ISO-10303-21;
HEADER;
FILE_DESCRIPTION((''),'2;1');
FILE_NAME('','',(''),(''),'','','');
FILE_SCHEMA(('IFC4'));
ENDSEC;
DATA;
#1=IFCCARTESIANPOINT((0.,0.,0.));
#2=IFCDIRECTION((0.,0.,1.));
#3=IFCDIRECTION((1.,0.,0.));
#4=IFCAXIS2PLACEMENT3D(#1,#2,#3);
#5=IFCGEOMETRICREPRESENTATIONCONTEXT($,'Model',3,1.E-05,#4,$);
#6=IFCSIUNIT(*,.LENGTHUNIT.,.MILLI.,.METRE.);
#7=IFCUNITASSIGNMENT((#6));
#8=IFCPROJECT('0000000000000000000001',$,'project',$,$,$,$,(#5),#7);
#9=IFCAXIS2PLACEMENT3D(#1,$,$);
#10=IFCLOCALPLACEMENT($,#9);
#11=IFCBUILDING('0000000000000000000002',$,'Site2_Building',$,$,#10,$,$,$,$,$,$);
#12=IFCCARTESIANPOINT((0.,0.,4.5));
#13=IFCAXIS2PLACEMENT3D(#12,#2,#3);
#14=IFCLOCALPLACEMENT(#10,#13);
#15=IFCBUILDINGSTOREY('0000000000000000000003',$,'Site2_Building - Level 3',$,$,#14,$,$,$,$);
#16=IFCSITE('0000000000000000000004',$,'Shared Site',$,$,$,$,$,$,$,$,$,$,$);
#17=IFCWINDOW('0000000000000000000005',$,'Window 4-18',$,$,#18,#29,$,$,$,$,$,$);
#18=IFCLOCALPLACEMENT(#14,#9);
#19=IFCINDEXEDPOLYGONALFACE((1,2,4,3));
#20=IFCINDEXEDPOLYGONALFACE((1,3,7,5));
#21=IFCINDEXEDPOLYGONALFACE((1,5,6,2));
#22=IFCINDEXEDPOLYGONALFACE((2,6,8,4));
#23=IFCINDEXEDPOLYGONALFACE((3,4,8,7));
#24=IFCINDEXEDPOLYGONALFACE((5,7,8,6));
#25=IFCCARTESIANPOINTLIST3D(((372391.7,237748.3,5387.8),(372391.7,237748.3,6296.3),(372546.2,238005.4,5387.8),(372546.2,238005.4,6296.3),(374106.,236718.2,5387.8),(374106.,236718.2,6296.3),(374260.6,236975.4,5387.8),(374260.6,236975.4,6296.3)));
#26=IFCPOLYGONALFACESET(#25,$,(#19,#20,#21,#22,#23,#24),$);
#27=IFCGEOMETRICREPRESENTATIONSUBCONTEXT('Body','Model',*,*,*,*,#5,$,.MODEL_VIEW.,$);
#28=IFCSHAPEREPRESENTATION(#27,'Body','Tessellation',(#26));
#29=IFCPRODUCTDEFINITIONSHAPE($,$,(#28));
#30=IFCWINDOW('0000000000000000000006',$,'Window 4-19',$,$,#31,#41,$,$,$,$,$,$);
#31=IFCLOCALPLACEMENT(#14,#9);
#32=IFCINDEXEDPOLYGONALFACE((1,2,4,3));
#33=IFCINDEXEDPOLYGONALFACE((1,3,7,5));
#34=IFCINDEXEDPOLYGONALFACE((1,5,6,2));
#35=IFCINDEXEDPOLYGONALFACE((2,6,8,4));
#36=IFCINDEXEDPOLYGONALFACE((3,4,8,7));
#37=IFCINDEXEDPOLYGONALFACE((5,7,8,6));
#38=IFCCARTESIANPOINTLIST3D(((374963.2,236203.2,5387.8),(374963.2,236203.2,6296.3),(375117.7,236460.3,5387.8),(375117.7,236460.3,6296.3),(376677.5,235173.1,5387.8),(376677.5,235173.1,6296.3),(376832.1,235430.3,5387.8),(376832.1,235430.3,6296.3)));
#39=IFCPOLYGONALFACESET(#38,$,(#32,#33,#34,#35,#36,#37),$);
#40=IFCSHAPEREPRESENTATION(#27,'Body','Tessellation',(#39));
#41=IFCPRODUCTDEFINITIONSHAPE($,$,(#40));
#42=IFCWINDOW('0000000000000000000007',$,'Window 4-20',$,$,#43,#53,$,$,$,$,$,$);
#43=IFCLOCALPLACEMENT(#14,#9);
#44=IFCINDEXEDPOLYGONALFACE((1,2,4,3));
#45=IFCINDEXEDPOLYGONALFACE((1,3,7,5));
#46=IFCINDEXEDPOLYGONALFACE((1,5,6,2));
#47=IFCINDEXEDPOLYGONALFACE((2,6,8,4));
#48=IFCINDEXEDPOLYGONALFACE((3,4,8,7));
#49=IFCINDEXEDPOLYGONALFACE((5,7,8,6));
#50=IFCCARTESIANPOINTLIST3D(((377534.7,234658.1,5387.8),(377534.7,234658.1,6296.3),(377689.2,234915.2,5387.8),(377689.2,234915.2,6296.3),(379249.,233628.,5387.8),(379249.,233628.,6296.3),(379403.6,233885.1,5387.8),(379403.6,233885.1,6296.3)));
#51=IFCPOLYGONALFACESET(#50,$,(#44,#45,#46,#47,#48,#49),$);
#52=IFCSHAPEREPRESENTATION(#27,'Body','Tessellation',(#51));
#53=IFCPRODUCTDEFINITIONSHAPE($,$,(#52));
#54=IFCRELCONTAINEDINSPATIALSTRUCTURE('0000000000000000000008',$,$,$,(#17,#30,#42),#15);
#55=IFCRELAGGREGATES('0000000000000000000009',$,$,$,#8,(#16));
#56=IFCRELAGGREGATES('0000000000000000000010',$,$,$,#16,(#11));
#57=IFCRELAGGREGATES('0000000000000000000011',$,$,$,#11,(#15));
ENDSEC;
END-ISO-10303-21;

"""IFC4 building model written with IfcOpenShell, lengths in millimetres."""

from ifc_helpers import new_model, si_unit, frame, origin, origin_with_axes, place, context, subcontext, project, spatial, indexed_curve, outline, extrude, element, save


model = new_model("IFC4")

# Units and contexts
model_context = context("Model", 3, precision=1e-05, world=origin_with_axes())
body_context = subcontext(model_context, "Body", "Model", "MODEL_VIEW")
ifc_project = project(units=[si_unit("LENGTHUNIT", "METRE", prefix="MILLI")], contexts=[model_context])

# Site, building, storey
site = spatial("IfcSite", under=ifc_project, Name="Shared Site")
building_placement = place(None, origin())
building = spatial("IfcBuilding", under=site, at=building_placement, Name="Site2_Building")
storey_placement = place(building_placement, frame((0.0, 0.0, 4.5), z_axis=(0.0, 0.0, 1.0), x_axis=(1.0, 0.0, 0.0)))
storey = spatial("IfcBuildingStorey", under=building, at=storey_placement, Name="Site2_Building - Level 3")

# Windows
for number, where, z_axis, x_axis, name in (
    (1, (372391.7, 237748.3, 5387.8), (0.0, 0.0, 1.0), (0.857167, -0.515038, 0.0), "Window 4-18"),
    (2, (374963.2, 236203.2, 5387.8), (0.0, 0.0, 1.0), (0.857167, -0.515038, 0.0), "Window 4-19"),
    (3, (377534.7, 234658.1, 5387.8), (0.0, 0.0, 1.0), (0.857167, -0.515038, 0.0), "Window 4-20"),
):
    element("IfcWindow", number, at=place(storey_placement, frame(where, z_axis=z_axis, x_axis=x_axis)), inside=storey, Name=name, context=body_context, shape_type="SweptSolid", body=[
        extrude(outline(indexed_curve([(0.0, 0.0), (0.0, 300.0), (2000.0, 300.0), (2000.0, 0.0), (0.0, 0.0)], self_intersect=False)), origin_with_axes(), (0.0, 0.0, 1.0), 908.6),
    ])

save(model, "model.ifc")
